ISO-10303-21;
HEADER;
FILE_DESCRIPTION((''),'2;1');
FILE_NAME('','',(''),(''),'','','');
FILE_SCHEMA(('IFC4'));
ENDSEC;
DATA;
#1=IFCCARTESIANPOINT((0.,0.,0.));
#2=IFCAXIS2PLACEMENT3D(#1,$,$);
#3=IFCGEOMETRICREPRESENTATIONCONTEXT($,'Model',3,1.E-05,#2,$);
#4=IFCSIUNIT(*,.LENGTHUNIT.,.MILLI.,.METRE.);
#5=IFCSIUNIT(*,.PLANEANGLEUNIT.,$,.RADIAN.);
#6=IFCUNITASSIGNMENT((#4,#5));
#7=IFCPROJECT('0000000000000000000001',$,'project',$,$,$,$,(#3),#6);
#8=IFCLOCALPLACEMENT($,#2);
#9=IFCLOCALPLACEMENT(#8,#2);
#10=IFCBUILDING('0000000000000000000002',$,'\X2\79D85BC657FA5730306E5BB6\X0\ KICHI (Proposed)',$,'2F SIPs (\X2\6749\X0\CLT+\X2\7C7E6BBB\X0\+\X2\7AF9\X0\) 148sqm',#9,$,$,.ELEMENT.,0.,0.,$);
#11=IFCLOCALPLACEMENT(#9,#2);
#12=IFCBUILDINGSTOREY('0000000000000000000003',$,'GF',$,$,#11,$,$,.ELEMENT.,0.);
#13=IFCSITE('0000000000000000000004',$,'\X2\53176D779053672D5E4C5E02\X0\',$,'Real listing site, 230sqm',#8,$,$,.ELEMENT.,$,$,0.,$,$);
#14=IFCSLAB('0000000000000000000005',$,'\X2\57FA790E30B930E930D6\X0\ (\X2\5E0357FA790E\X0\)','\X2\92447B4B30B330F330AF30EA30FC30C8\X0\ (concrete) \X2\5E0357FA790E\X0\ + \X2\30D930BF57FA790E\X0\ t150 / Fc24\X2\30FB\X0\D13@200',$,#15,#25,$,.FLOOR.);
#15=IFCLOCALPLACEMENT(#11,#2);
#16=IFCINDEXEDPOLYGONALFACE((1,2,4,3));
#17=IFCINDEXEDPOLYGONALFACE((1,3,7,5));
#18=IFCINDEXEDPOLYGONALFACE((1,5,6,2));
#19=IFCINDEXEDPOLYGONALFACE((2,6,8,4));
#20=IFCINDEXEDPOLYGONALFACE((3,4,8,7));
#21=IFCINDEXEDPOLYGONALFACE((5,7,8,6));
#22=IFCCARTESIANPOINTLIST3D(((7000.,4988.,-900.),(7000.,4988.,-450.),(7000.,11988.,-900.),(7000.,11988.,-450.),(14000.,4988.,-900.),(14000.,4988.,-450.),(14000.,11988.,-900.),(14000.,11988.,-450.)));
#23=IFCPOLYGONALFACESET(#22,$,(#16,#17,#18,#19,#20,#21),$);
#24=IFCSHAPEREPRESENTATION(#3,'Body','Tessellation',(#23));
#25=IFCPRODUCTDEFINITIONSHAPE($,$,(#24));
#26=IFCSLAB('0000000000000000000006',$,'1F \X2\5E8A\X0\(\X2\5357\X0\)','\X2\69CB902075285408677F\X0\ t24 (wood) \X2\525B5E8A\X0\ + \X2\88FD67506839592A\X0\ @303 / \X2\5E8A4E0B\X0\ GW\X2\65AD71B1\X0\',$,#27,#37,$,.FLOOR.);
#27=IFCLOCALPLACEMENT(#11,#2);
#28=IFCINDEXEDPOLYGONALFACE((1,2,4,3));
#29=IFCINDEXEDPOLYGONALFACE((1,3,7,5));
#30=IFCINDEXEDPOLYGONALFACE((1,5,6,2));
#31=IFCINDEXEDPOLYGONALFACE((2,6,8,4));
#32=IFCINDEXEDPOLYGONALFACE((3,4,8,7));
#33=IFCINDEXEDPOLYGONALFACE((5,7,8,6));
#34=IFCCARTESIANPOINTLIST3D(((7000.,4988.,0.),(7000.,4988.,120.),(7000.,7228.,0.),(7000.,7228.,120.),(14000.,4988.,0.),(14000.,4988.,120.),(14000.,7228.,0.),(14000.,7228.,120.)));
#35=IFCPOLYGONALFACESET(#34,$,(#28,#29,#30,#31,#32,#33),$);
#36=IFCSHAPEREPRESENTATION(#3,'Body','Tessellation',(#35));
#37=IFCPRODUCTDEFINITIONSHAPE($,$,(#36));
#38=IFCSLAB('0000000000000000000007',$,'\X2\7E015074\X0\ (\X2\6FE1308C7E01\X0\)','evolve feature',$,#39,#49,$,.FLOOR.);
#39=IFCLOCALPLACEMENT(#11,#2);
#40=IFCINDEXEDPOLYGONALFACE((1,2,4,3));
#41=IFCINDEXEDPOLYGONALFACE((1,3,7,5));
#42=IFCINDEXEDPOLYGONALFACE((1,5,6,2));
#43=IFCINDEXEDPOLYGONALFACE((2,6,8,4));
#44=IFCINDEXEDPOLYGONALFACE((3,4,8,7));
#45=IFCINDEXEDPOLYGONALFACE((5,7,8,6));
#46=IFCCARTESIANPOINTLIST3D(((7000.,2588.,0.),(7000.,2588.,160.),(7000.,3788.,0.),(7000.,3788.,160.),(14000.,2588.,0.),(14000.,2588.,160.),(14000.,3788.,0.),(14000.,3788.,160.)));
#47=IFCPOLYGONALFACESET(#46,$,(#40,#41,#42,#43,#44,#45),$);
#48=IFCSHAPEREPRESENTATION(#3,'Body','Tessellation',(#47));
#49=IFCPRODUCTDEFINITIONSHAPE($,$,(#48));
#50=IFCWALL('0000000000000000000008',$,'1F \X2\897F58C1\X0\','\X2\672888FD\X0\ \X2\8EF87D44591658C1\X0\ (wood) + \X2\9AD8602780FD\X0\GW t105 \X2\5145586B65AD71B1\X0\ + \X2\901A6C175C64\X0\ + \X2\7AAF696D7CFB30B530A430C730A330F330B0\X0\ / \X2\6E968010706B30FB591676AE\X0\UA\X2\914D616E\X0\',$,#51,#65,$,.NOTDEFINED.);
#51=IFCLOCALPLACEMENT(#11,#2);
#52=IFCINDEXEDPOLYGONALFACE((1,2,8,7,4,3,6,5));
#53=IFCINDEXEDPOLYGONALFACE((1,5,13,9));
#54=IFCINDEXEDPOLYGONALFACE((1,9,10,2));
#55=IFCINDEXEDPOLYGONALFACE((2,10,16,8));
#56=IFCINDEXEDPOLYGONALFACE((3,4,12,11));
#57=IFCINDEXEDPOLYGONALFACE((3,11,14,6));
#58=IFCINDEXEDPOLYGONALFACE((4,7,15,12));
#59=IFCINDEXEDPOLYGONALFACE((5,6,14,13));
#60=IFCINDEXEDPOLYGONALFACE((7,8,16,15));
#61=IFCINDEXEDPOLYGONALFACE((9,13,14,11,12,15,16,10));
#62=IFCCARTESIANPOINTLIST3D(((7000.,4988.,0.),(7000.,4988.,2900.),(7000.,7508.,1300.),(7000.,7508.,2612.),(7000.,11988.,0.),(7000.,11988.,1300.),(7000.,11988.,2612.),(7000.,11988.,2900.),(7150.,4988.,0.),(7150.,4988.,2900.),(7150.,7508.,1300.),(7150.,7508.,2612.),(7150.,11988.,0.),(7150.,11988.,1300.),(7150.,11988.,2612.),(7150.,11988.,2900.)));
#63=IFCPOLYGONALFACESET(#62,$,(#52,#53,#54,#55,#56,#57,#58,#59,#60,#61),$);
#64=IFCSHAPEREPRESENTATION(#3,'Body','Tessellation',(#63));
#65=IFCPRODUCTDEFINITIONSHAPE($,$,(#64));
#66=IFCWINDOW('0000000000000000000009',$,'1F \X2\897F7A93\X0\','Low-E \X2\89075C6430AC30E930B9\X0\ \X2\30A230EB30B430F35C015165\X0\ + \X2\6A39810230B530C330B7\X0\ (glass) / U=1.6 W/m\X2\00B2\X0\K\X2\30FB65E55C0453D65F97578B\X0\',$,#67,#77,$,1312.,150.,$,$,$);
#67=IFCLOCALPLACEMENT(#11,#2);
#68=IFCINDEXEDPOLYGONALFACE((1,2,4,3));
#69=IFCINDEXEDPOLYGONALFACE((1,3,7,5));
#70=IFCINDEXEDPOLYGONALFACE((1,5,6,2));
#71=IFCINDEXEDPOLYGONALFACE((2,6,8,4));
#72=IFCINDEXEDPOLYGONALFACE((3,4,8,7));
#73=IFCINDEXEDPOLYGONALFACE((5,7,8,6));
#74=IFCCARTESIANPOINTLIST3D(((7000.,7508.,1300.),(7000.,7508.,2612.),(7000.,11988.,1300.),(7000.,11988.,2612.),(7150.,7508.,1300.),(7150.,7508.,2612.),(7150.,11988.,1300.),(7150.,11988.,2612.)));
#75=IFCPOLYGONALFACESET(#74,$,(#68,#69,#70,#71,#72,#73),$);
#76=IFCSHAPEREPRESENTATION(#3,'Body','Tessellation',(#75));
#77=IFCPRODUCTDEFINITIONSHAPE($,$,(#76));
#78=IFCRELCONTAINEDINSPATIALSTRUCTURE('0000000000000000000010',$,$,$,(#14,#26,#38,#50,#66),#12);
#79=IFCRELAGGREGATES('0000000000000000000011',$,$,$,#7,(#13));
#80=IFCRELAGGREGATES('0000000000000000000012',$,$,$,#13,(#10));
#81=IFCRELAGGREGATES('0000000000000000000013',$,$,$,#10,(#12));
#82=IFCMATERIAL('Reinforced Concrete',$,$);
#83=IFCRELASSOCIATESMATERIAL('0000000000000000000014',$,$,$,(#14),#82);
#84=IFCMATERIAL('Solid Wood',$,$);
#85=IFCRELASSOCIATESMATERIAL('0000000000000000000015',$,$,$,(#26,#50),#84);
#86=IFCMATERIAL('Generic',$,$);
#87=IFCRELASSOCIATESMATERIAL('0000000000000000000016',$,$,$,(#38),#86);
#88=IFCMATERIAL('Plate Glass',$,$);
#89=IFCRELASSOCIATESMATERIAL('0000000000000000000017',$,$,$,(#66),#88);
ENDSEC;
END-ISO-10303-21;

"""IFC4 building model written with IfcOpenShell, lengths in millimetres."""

from ifc_helpers import new_model, si_unit, frame, frame_2d, origin, place, context, project, spatial, rectangle, extrude, material, element, fill, save


model = new_model("IFC4")

# Units and contexts
model_context = context("Model", 3, precision=1e-05, world=origin())
ifc_project = project(units=[si_unit("LENGTHUNIT", "METRE", prefix="MILLI"), si_unit("PLANEANGLEUNIT", "RADIAN")], contexts=[model_context])

# Site, building, storey
site_placement = place(None, origin())
site = spatial("IfcSite", under=ifc_project, at=site_placement, Name="北海道札幌市", ObjectType="Real listing site, 230sqm", CompositionType="ELEMENT", RefElevation=0.0)
building_placement = place(site_placement, origin())
building = spatial("IfcBuilding", under=site, at=building_placement, Name="秘密基地の家 KICHI (Proposed)", ObjectType="2F SIPs (杉CLT+籾殻+竹) 148sqm", CompositionType="ELEMENT", ElevationOfRefHeight=0.0, ElevationOfTerrain=0.0)
storey_placement = place(building_placement, origin())
storey = spatial("IfcBuildingStorey", under=building, at=storey_placement, Name="GF", CompositionType="ELEMENT", Elevation=0.0)

# Slabs
ifc_material_1 = material(Name="Reinforced Concrete")
slab_1_placement = place(storey_placement, frame((3500.0, 2494.0, -450.0)))
element("IfcSlab", 1, at=slab_1_placement, inside=storey, material=ifc_material_1, Name="基礎スラブ (布基礎)", Description="鉄筋コンクリート (concrete) 布基礎 + ベタ基礎 t150 / Fc24・D13@200", PredefinedType="FLOOR", context=model_context, shape_type="SweptSolid", body=[
    extrude(rectangle(XDim=7000.0, YDim=7000.0, at=frame_2d((3500.0, 3500.0))), frame((3500.0, 2494.0, -450.0)), (0.0, 0.0, 1.0), 450.0),
])
ifc_material_2 = material(Name="Solid Wood")
slab_2_placement = place(storey_placement, frame((3500.0, 2494.0, 0.0)))
element("IfcSlab", 2, at=slab_2_placement, inside=storey, material=ifc_material_2, Name="1F 床(南)", Description="構造用合板 t24 (wood) 剛床 + 製材根太 @303 / 床下 GW断熱", PredefinedType="FLOOR", context=model_context, shape_type="SweptSolid", body=[
    extrude(rectangle(XDim=7000.0, YDim=2240.0, at=frame_2d((3500.0, 1120.0))), frame((3500.0, 2494.0, 0.0)), (0.0, 0.0, 1.0), 120.0),
])
ifc_material_3 = material(Name="Generic")
slab_3_placement = place(storey_placement, frame((3500.0, 1294.0, 0.0)))
element("IfcSlab", 3, at=slab_3_placement, inside=storey, material=ifc_material_3, Name="縁側 (濡れ縁)", Description="evolve feature", PredefinedType="FLOOR", context=model_context, shape_type="SweptSolid", body=[
    extrude(rectangle(XDim=7000.0, YDim=1200.0, at=frame_2d((3500.0, 600.0))), frame((3500.0, 1294.0, 0.0)), (0.0, 0.0, 1.0), 160.0),
])

# Shared definitions
ifc_material_4 = material(Name="Plate Glass")

# Wall, opening, window
wall_1_placement = place(storey_placement, frame((3500.0, 2494.0, 0.0)))
wall_1 = element("IfcWall", 4, at=wall_1_placement, inside=storey, material=ifc_material_2, Name="1F 西壁", Description="木製 軸組外壁 (wood) + 高性能GW t105 充填断熱 + 通気層 + 窯業系サイディング / 準耐火・外皮UA配慮", PredefinedType="NOTDEFINED", context=model_context, shape_type="SweptSolid", body=[
    extrude(rectangle(XDim=150.0, YDim=7000.0, at=frame_2d((75.0, 3500.0))), frame((3500.0, 2494.0, 0.0)), (0.0, 0.0, 1.0), 2900.0),
])
opening_1_placement = place(storey_placement, frame((3500.0, 3754.0, 650.0)))
opening_1 = element("IfcOpeningElement", 5, at=opening_1_placement, cuts=wall_1, PredefinedType="NOTDEFINED", context=model_context, shape_type="SweptSolid", body=[
    extrude(rectangle(XDim=150.0, YDim=4480.0, at=frame_2d((75.0, 2240.0))), frame((3500.0, 3754.0, 650.0)), (0.0, 0.0, 1.0), 1312.0),
])
window_1_placement = place(storey_placement, frame((3500.0, 3754.0, 650.0)))
window_1 = element("IfcWindow", 6, at=window_1_placement, inside=storey, material=ifc_material_4, Name="1F 西窓", Description="Low-E 複層ガラス アルゴン封入 + 樹脂サッシ (glass) / U=1.6 W/m²K・日射取得型", OverallHeight=1312.0, OverallWidth=150.0, context=model_context, shape_type="SweptSolid", body=[
    extrude(rectangle(XDim=150.0, YDim=4480.0, at=frame_2d((75.0, 2240.0))), frame((3500.0, 3754.0, 650.0)), (0.0, 0.0, 1.0), 1312.0),
])
fill(opening_1, window_1)

save(model, "model.ifc")
